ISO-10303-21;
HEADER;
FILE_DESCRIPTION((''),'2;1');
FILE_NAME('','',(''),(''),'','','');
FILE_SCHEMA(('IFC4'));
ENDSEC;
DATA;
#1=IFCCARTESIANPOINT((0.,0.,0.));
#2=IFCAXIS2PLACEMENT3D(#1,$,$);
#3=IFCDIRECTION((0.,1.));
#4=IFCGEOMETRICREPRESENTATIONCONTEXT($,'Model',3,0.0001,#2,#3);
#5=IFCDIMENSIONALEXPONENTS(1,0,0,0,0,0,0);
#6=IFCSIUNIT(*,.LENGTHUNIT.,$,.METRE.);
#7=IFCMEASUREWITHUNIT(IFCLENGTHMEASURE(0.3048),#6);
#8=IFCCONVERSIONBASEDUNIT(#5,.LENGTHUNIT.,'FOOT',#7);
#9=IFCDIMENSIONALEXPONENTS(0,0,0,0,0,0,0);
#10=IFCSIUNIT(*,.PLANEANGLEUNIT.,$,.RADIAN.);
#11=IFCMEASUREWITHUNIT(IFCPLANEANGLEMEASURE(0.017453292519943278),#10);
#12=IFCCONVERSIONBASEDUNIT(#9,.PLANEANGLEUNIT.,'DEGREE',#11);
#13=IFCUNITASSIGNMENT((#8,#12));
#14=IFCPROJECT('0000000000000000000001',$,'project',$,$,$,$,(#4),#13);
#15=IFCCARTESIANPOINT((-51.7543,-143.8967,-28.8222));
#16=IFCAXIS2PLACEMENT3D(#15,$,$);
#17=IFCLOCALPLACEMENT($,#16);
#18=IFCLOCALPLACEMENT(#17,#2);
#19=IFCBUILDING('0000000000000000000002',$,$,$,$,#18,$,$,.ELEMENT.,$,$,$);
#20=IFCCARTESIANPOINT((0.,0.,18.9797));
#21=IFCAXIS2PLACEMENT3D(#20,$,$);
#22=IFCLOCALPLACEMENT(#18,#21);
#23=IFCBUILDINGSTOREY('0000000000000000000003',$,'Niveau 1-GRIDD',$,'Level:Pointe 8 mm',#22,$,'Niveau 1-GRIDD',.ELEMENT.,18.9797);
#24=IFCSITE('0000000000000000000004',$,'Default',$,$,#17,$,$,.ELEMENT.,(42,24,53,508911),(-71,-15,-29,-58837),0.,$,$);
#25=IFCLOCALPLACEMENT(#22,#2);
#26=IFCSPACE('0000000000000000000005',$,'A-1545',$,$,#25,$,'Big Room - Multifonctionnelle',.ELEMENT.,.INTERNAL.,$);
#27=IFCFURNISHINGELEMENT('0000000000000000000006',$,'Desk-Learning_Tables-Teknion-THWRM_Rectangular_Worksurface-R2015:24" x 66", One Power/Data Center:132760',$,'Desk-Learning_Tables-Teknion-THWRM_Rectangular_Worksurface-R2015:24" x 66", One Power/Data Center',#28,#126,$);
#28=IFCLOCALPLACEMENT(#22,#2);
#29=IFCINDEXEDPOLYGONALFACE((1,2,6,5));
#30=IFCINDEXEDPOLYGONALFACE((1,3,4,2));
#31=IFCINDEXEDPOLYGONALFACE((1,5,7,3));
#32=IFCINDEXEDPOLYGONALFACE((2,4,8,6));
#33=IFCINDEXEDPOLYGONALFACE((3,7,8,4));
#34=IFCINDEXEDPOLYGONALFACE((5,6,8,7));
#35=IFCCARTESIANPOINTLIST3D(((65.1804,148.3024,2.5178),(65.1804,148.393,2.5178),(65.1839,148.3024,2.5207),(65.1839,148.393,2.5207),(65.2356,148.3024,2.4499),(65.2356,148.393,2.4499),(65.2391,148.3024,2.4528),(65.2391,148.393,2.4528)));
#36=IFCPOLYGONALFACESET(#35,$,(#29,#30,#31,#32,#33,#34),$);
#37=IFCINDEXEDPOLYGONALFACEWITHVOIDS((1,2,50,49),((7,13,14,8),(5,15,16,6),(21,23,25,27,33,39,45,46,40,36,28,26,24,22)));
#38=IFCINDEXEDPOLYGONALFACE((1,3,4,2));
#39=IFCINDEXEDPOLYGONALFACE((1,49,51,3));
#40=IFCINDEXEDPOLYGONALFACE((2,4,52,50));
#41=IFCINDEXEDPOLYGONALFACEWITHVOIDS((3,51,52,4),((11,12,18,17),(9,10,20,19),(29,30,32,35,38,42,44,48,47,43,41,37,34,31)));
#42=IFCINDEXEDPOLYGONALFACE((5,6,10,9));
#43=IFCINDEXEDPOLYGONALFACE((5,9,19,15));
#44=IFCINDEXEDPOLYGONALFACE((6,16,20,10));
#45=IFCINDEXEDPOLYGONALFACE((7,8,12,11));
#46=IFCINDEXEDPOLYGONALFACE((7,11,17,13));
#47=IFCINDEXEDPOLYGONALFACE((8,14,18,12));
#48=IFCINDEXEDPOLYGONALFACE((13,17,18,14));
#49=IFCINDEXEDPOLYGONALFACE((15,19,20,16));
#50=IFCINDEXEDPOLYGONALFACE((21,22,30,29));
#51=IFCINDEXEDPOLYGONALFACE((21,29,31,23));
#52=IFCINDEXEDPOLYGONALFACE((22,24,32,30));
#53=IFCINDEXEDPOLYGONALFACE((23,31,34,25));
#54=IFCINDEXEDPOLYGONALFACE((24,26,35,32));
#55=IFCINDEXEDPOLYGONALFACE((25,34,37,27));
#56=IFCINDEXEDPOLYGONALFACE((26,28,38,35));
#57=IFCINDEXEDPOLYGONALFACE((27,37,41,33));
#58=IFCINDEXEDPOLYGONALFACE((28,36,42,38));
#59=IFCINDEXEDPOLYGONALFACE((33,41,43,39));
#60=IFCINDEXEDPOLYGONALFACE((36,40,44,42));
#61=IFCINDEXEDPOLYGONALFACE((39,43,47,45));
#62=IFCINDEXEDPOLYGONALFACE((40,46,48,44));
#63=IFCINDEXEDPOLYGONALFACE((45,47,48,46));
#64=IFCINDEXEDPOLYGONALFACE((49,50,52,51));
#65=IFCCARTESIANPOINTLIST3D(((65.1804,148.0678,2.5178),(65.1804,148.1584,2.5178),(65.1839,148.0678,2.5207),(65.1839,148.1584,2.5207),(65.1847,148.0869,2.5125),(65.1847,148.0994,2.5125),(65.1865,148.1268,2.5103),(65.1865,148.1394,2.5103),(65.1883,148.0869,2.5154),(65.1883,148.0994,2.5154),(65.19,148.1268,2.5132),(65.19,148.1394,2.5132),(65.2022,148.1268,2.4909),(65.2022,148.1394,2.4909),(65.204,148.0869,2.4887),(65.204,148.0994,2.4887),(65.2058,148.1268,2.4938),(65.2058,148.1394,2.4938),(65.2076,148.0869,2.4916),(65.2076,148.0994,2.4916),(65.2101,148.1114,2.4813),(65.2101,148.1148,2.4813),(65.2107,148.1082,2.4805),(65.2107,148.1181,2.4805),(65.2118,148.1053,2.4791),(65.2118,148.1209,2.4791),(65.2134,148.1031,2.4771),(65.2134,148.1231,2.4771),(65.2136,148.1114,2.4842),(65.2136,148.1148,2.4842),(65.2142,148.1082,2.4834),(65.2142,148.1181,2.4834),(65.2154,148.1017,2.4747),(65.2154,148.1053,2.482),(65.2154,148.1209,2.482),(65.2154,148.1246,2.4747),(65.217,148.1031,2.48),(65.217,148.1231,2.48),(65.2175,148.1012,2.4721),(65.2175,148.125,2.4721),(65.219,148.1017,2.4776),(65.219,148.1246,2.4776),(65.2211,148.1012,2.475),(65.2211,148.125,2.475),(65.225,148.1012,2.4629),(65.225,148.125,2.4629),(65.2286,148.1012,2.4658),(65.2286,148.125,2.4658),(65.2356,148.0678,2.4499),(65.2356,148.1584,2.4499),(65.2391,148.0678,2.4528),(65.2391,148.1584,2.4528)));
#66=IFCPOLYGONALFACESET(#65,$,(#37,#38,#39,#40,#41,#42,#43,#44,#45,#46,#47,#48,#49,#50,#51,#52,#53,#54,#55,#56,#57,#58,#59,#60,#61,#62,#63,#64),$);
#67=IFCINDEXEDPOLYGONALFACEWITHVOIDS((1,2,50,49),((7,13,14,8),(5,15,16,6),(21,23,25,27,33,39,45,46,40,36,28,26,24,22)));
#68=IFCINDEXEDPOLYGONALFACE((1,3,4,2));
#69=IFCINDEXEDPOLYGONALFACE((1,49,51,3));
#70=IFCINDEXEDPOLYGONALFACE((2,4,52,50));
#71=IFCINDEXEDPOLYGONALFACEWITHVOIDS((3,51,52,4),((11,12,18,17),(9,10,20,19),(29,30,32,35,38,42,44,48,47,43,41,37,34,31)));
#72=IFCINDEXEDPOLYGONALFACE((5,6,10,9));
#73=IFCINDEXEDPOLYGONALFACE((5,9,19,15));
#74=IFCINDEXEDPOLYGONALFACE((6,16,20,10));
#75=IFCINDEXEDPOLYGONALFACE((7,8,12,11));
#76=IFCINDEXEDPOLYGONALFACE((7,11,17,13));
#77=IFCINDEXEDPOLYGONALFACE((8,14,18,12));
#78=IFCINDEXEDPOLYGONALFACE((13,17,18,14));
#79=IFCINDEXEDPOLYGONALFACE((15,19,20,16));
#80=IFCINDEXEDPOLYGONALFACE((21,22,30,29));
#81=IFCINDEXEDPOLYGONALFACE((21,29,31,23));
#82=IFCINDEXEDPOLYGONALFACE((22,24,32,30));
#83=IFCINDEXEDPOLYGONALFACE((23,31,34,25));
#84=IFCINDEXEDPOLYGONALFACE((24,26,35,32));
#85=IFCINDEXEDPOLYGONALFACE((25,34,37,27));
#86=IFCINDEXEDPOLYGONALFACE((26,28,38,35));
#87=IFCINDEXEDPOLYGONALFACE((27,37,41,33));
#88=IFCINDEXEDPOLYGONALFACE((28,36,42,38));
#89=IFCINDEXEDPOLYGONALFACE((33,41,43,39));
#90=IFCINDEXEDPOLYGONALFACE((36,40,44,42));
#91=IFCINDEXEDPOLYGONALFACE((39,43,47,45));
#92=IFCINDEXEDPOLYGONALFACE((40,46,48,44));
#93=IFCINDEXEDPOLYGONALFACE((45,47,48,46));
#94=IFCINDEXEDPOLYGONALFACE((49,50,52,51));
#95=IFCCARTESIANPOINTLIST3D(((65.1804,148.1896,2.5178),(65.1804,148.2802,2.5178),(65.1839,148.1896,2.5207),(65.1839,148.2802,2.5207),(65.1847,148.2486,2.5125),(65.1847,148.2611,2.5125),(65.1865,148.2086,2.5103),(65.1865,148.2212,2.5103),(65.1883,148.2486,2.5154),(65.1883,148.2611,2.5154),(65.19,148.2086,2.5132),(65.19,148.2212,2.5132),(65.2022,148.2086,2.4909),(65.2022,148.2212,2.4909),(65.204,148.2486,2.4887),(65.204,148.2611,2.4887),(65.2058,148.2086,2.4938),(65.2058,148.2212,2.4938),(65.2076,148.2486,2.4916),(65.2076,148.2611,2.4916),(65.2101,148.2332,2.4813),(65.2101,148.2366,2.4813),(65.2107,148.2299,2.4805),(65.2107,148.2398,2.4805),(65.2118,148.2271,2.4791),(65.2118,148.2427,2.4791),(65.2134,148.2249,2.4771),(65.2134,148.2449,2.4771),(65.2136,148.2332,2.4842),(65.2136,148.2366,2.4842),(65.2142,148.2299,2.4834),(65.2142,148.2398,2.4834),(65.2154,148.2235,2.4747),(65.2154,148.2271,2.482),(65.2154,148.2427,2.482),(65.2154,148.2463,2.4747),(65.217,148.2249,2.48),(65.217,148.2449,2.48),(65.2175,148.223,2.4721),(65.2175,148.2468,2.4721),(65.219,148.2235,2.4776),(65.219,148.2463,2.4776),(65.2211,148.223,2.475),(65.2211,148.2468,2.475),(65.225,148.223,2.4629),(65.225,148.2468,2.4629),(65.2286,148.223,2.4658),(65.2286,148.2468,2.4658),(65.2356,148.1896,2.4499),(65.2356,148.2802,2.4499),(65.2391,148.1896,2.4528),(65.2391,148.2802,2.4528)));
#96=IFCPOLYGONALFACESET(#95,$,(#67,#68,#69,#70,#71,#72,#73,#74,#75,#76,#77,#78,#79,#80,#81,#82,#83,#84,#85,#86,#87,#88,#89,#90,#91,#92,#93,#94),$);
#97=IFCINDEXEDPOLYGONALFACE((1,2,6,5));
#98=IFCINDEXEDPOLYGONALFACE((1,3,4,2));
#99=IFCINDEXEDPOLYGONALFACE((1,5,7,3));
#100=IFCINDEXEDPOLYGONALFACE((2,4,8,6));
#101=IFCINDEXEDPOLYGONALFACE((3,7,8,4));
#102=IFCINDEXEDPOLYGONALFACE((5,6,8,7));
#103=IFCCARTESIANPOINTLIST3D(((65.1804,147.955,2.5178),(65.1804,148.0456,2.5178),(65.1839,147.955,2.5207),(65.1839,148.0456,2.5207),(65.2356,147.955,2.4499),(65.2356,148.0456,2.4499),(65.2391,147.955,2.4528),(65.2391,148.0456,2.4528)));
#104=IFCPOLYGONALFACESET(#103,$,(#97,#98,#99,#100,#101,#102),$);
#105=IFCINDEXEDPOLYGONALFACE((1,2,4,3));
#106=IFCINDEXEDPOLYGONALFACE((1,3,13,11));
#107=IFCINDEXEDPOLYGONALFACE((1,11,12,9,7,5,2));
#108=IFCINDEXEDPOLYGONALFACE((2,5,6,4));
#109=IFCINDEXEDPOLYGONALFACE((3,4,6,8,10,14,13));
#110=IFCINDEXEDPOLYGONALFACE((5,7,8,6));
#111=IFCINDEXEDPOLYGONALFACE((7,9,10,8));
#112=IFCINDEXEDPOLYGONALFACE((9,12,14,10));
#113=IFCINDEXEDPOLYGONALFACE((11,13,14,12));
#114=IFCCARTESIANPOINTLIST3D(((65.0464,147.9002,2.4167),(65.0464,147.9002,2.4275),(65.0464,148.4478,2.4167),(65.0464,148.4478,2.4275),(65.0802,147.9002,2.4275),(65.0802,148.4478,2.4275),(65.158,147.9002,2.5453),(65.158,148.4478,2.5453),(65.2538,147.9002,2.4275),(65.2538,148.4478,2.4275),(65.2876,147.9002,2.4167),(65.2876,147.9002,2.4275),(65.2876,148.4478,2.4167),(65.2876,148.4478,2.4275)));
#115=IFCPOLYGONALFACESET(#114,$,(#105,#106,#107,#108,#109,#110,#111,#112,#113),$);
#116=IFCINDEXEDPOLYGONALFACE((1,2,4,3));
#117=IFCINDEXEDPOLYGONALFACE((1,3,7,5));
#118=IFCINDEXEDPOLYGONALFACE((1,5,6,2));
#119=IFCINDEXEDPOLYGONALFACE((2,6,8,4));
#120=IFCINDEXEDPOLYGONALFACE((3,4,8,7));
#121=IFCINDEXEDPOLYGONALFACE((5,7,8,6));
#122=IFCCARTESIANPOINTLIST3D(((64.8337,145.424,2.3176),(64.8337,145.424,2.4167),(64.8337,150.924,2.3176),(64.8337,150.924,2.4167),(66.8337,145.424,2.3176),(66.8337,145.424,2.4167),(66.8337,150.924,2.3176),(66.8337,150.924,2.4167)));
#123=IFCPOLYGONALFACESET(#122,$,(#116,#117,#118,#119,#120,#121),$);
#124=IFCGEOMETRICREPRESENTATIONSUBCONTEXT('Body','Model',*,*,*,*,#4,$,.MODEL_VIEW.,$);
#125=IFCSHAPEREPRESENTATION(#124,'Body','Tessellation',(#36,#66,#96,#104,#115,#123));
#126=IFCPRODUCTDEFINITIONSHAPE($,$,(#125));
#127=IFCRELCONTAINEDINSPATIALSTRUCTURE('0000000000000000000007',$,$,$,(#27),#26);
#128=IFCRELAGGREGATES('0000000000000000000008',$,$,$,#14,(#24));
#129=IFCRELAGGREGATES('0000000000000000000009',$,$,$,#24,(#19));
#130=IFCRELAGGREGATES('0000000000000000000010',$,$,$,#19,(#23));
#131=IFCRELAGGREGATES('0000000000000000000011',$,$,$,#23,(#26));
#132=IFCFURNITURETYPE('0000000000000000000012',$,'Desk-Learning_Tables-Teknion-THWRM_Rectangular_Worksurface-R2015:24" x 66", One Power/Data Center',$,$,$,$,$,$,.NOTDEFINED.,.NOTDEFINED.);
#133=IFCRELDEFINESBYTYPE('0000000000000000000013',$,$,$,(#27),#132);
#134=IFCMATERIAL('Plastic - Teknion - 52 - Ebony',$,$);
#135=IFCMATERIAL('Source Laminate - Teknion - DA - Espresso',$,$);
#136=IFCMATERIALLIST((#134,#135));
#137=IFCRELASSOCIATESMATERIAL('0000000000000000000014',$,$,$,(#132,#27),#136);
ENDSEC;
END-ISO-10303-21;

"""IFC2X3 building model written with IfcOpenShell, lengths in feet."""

from ifc_helpers import new_model, entity, si_unit, converted_unit, direction, frame, frame_2d, origin, place, context, subcontext, project, spatial, polyline, circle_curve, parameter, trimmed, segment, composite_curve, rectangle, outline, extrude, source, transform, mapped, material, material_list, type_object, type_shapes, element, save


model = new_model("IFC2X3")

# Units and contexts
model_context = context("Model", 3, precision=0.0001, world=origin(), true_north=direction((0.0, 1.0)))
body_context = subcontext(model_context, "Body", "Model", "MODEL_VIEW")
ifc_project = project(units=[converted_unit("LENGTHUNIT", "FOOT", entity("IfcLengthMeasure", 0.3048), si_unit("LENGTHUNIT", "METRE"), dimensions=[1, 0, 0, 0, 0, 0, 0]), converted_unit("PLANEANGLEUNIT", "DEGREE", entity("IfcPlaneAngleMeasure", 0.017453292519943278), si_unit("PLANEANGLEUNIT", "RADIAN"), dimensions=[0, 0, 0, 0, 0, 0, 0])], contexts=[model_context])

# Site, building, storey
site_placement = place(None, frame((-51.7543, -143.8967, -28.8222)))
site = spatial("IfcSite", under=ifc_project, at=site_placement, Name="Default", CompositionType="ELEMENT", RefLatitude=(42, 24, 53, 508911), RefLongitude=(-71, -15, -29, -58837), RefElevation=0.0)
building_placement = place(site_placement, origin())
building = spatial("IfcBuilding", under=site, at=building_placement, CompositionType="ELEMENT")
storey_placement = place(building_placement, frame((0.0, 0.0, 18.9797)))
storey = spatial("IfcBuildingStorey", under=building, at=storey_placement, Name="Niveau 1-GRIDD", ObjectType="Level:Pointe 8 mm", LongName="Niveau 1-GRIDD", CompositionType="ELEMENT", Elevation=18.9797)

# Shared definitions
space_placement = place(storey_placement, origin())
space = spatial("IfcSpace", under=storey, at=space_placement, Name="A-1545", LongName="Big Room - Multifonctionnelle", CompositionType="ELEMENT", InteriorOrExteriorSpace="INTERNAL")

# Furnishing element
ifc_material_1 = material(Name="Plastic - Teknion - 52 - Ebony")
ifc_material_2 = material(Name="Source Laminate - Teknion - DA - Espresso")
ifc_material_list_1 = material_list([ifc_material_1, ifc_material_2])
furniture_type_1 = type_object("IfcFurnitureType", Name="Desk-Learning_Tables-Teknion-THWRM_Rectangular_Worksurface-R2015:24\" x 66\", One Power/Data Center", AssemblyPlace="NOTDEFINED", material=ifc_material_list_1)
shared_shape_1 = source(origin(), body_context, "Body", "SweptSolid", [
    extrude(rectangle(XDim=0.0875, YDim=0.0046, at=frame_2d((0.0, 0.0), x_axis=(0.0, 1.0))), frame((0.1284, 0.6239, 2.4853), z_axis=(1.0, 0.0, 0.0), x_axis=(0.0, 0.776046, -0.630676)), (0.0, 0.0, 1.0), 0.0906),
    extrude(outline(polyline([(-0.0453, -0.0438), (0.0453, -0.0438), (0.0453, 0.0438), (-0.0453, 0.0438), (-0.0453, -0.0438)]), holes=[polyline([(-0.0262, -0.0063), (-0.0137, -0.0063), (-0.0137, -0.0369), (-0.0262, -0.0369), (-0.0262, -0.0063)]), polyline([(0.0137, -0.0341), (0.0137, -0.0091), (0.0262, -0.0091), (0.0262, -0.0341), (0.0137, -0.0341)]), composite_curve([segment(polyline([(-0.0119, 0.027), (0.0119, 0.027)]), True, "CONTINUOUS"), segment(polyline([(0.0119, 0.027), (0.0119, 0.0151)]), True, "CONTINUOUS"), segment(trimmed(circle_curve(frame_2d((0.0, 0.0151), x_axis=(0.0, -1.0)), 0.0119), [parameter(270.0)], [parameter(90.0)], True, "PARAMETER"), False, "CONTINUOUS"), segment(polyline([(-0.0119, 0.0151), (-0.0119, 0.027)]), True, "CONTINUOUS")], self_intersect=False)]), frame((-0.0609, 0.6221, 2.4867), z_axis=(0.0, 0.776046, -0.630676), x_axis=(1.0, 0.0, 0.0)), (0.0, 0.0, 1.0), 0.0046),
    extrude(outline(polyline([(-0.0438, -0.0453), (0.0438, -0.0453), (0.0438, 0.0453), (-0.0438, 0.0453), (-0.0438, -0.0453)]), holes=[polyline([(-0.0063, -0.0262), (-0.0369, -0.0262), (-0.0369, -0.0137), (-0.0063, -0.0137), (-0.0063, -0.0262)]), polyline([(-0.0341, 0.0137), (-0.0341, 0.0262), (-0.0091, 0.0262), (-0.0091, 0.0137), (-0.0341, 0.0137)]), composite_curve([segment(polyline([(0.027, -0.0119), (0.0151, -0.0119)]), True, "CONTINUOUS"), segment(trimmed(circle_curve(frame_2d((0.0151, 0.0), x_axis=(-1.0, 0.0)), 0.0119), [parameter(270.0)], [parameter(90.0)], True, "PARAMETER"), False, "CONTINUOUS"), segment(polyline([(0.0151, 0.0119), (0.027, 0.0119)]), True, "CONTINUOUS"), segment(polyline([(0.027, 0.0119), (0.027, -0.0119)]), True, "CONTINUOUS")], self_intersect=False)]), frame((0.0609, 0.6221, 2.4867), z_axis=(0.0, 0.776046, -0.630676), x_axis=(0.0, -0.630676, -0.776046)), (0.0, 0.0, 1.0), 0.0046),
    extrude(rectangle(XDim=0.0875, YDim=0.0046, at=frame_2d((0.0, 0.0), x_axis=(0.0, 1.0))), frame((-0.219, 0.6239, 2.4853), z_axis=(1.0, 0.0, 0.0), x_axis=(0.0, 0.776046, -0.630676)), (0.0, 0.0, 1.0), 0.0906),
    extrude(outline(polyline([(-0.0586, -0.0638), (0.0826, -0.0638), (0.0371, 0.0811), (0.0557, 0.1093), (0.0467, 0.1152), (-0.0862, -0.086), (-0.0772, -0.092), (-0.0586, -0.0638)])), frame((-0.2738, 0.6679, 2.4412), z_axis=(1.0, 0.0, 0.0), x_axis=(0.0, -0.551103, 0.834437)), (0.0, 0.0, 1.0), 0.5475),
    extrude(rectangle(XDim=5.5, YDim=2.0, at=frame_2d((0.0, 0.0), x_axis=(1.0, 0.0))), frame((0.0, 0.0, 2.3176), z_axis=(0.0, 0.0, 1.0), x_axis=(-1.0, 0.0, 0.0)), (0.0, 0.0, 1.0), 0.0991),
])
type_shapes(furniture_type_1, [shared_shape_1])
for number, where, z_axis, x_axis, name in (
    (1, (65.8337, 148.174, 0.0), (0.0, 0.0, 1.0), (0.0, 1.0, 0.0), "Desk-Learning_Tables-Teknion-THWRM_Rectangular_Worksurface-R2015:24\" x 66\", One Power/Data Center:132760"),
):
    element("IfcFurnishingElement", number, at=place(space_placement, frame(where, z_axis=z_axis, x_axis=x_axis)), inside=space, type_object=furniture_type_1, material=ifc_material_list_1, Name=name, ObjectType="Desk-Learning_Tables-Teknion-THWRM_Rectangular_Worksurface-R2015:24\" x 66\", One Power/Data Center", context=body_context, shape_type="MappedRepresentation", body=[
        mapped(shared_shape_1, transform((0.0, 0.0, 0.0), scale=1.0)),
    ])

save(model, "model.ifc")
